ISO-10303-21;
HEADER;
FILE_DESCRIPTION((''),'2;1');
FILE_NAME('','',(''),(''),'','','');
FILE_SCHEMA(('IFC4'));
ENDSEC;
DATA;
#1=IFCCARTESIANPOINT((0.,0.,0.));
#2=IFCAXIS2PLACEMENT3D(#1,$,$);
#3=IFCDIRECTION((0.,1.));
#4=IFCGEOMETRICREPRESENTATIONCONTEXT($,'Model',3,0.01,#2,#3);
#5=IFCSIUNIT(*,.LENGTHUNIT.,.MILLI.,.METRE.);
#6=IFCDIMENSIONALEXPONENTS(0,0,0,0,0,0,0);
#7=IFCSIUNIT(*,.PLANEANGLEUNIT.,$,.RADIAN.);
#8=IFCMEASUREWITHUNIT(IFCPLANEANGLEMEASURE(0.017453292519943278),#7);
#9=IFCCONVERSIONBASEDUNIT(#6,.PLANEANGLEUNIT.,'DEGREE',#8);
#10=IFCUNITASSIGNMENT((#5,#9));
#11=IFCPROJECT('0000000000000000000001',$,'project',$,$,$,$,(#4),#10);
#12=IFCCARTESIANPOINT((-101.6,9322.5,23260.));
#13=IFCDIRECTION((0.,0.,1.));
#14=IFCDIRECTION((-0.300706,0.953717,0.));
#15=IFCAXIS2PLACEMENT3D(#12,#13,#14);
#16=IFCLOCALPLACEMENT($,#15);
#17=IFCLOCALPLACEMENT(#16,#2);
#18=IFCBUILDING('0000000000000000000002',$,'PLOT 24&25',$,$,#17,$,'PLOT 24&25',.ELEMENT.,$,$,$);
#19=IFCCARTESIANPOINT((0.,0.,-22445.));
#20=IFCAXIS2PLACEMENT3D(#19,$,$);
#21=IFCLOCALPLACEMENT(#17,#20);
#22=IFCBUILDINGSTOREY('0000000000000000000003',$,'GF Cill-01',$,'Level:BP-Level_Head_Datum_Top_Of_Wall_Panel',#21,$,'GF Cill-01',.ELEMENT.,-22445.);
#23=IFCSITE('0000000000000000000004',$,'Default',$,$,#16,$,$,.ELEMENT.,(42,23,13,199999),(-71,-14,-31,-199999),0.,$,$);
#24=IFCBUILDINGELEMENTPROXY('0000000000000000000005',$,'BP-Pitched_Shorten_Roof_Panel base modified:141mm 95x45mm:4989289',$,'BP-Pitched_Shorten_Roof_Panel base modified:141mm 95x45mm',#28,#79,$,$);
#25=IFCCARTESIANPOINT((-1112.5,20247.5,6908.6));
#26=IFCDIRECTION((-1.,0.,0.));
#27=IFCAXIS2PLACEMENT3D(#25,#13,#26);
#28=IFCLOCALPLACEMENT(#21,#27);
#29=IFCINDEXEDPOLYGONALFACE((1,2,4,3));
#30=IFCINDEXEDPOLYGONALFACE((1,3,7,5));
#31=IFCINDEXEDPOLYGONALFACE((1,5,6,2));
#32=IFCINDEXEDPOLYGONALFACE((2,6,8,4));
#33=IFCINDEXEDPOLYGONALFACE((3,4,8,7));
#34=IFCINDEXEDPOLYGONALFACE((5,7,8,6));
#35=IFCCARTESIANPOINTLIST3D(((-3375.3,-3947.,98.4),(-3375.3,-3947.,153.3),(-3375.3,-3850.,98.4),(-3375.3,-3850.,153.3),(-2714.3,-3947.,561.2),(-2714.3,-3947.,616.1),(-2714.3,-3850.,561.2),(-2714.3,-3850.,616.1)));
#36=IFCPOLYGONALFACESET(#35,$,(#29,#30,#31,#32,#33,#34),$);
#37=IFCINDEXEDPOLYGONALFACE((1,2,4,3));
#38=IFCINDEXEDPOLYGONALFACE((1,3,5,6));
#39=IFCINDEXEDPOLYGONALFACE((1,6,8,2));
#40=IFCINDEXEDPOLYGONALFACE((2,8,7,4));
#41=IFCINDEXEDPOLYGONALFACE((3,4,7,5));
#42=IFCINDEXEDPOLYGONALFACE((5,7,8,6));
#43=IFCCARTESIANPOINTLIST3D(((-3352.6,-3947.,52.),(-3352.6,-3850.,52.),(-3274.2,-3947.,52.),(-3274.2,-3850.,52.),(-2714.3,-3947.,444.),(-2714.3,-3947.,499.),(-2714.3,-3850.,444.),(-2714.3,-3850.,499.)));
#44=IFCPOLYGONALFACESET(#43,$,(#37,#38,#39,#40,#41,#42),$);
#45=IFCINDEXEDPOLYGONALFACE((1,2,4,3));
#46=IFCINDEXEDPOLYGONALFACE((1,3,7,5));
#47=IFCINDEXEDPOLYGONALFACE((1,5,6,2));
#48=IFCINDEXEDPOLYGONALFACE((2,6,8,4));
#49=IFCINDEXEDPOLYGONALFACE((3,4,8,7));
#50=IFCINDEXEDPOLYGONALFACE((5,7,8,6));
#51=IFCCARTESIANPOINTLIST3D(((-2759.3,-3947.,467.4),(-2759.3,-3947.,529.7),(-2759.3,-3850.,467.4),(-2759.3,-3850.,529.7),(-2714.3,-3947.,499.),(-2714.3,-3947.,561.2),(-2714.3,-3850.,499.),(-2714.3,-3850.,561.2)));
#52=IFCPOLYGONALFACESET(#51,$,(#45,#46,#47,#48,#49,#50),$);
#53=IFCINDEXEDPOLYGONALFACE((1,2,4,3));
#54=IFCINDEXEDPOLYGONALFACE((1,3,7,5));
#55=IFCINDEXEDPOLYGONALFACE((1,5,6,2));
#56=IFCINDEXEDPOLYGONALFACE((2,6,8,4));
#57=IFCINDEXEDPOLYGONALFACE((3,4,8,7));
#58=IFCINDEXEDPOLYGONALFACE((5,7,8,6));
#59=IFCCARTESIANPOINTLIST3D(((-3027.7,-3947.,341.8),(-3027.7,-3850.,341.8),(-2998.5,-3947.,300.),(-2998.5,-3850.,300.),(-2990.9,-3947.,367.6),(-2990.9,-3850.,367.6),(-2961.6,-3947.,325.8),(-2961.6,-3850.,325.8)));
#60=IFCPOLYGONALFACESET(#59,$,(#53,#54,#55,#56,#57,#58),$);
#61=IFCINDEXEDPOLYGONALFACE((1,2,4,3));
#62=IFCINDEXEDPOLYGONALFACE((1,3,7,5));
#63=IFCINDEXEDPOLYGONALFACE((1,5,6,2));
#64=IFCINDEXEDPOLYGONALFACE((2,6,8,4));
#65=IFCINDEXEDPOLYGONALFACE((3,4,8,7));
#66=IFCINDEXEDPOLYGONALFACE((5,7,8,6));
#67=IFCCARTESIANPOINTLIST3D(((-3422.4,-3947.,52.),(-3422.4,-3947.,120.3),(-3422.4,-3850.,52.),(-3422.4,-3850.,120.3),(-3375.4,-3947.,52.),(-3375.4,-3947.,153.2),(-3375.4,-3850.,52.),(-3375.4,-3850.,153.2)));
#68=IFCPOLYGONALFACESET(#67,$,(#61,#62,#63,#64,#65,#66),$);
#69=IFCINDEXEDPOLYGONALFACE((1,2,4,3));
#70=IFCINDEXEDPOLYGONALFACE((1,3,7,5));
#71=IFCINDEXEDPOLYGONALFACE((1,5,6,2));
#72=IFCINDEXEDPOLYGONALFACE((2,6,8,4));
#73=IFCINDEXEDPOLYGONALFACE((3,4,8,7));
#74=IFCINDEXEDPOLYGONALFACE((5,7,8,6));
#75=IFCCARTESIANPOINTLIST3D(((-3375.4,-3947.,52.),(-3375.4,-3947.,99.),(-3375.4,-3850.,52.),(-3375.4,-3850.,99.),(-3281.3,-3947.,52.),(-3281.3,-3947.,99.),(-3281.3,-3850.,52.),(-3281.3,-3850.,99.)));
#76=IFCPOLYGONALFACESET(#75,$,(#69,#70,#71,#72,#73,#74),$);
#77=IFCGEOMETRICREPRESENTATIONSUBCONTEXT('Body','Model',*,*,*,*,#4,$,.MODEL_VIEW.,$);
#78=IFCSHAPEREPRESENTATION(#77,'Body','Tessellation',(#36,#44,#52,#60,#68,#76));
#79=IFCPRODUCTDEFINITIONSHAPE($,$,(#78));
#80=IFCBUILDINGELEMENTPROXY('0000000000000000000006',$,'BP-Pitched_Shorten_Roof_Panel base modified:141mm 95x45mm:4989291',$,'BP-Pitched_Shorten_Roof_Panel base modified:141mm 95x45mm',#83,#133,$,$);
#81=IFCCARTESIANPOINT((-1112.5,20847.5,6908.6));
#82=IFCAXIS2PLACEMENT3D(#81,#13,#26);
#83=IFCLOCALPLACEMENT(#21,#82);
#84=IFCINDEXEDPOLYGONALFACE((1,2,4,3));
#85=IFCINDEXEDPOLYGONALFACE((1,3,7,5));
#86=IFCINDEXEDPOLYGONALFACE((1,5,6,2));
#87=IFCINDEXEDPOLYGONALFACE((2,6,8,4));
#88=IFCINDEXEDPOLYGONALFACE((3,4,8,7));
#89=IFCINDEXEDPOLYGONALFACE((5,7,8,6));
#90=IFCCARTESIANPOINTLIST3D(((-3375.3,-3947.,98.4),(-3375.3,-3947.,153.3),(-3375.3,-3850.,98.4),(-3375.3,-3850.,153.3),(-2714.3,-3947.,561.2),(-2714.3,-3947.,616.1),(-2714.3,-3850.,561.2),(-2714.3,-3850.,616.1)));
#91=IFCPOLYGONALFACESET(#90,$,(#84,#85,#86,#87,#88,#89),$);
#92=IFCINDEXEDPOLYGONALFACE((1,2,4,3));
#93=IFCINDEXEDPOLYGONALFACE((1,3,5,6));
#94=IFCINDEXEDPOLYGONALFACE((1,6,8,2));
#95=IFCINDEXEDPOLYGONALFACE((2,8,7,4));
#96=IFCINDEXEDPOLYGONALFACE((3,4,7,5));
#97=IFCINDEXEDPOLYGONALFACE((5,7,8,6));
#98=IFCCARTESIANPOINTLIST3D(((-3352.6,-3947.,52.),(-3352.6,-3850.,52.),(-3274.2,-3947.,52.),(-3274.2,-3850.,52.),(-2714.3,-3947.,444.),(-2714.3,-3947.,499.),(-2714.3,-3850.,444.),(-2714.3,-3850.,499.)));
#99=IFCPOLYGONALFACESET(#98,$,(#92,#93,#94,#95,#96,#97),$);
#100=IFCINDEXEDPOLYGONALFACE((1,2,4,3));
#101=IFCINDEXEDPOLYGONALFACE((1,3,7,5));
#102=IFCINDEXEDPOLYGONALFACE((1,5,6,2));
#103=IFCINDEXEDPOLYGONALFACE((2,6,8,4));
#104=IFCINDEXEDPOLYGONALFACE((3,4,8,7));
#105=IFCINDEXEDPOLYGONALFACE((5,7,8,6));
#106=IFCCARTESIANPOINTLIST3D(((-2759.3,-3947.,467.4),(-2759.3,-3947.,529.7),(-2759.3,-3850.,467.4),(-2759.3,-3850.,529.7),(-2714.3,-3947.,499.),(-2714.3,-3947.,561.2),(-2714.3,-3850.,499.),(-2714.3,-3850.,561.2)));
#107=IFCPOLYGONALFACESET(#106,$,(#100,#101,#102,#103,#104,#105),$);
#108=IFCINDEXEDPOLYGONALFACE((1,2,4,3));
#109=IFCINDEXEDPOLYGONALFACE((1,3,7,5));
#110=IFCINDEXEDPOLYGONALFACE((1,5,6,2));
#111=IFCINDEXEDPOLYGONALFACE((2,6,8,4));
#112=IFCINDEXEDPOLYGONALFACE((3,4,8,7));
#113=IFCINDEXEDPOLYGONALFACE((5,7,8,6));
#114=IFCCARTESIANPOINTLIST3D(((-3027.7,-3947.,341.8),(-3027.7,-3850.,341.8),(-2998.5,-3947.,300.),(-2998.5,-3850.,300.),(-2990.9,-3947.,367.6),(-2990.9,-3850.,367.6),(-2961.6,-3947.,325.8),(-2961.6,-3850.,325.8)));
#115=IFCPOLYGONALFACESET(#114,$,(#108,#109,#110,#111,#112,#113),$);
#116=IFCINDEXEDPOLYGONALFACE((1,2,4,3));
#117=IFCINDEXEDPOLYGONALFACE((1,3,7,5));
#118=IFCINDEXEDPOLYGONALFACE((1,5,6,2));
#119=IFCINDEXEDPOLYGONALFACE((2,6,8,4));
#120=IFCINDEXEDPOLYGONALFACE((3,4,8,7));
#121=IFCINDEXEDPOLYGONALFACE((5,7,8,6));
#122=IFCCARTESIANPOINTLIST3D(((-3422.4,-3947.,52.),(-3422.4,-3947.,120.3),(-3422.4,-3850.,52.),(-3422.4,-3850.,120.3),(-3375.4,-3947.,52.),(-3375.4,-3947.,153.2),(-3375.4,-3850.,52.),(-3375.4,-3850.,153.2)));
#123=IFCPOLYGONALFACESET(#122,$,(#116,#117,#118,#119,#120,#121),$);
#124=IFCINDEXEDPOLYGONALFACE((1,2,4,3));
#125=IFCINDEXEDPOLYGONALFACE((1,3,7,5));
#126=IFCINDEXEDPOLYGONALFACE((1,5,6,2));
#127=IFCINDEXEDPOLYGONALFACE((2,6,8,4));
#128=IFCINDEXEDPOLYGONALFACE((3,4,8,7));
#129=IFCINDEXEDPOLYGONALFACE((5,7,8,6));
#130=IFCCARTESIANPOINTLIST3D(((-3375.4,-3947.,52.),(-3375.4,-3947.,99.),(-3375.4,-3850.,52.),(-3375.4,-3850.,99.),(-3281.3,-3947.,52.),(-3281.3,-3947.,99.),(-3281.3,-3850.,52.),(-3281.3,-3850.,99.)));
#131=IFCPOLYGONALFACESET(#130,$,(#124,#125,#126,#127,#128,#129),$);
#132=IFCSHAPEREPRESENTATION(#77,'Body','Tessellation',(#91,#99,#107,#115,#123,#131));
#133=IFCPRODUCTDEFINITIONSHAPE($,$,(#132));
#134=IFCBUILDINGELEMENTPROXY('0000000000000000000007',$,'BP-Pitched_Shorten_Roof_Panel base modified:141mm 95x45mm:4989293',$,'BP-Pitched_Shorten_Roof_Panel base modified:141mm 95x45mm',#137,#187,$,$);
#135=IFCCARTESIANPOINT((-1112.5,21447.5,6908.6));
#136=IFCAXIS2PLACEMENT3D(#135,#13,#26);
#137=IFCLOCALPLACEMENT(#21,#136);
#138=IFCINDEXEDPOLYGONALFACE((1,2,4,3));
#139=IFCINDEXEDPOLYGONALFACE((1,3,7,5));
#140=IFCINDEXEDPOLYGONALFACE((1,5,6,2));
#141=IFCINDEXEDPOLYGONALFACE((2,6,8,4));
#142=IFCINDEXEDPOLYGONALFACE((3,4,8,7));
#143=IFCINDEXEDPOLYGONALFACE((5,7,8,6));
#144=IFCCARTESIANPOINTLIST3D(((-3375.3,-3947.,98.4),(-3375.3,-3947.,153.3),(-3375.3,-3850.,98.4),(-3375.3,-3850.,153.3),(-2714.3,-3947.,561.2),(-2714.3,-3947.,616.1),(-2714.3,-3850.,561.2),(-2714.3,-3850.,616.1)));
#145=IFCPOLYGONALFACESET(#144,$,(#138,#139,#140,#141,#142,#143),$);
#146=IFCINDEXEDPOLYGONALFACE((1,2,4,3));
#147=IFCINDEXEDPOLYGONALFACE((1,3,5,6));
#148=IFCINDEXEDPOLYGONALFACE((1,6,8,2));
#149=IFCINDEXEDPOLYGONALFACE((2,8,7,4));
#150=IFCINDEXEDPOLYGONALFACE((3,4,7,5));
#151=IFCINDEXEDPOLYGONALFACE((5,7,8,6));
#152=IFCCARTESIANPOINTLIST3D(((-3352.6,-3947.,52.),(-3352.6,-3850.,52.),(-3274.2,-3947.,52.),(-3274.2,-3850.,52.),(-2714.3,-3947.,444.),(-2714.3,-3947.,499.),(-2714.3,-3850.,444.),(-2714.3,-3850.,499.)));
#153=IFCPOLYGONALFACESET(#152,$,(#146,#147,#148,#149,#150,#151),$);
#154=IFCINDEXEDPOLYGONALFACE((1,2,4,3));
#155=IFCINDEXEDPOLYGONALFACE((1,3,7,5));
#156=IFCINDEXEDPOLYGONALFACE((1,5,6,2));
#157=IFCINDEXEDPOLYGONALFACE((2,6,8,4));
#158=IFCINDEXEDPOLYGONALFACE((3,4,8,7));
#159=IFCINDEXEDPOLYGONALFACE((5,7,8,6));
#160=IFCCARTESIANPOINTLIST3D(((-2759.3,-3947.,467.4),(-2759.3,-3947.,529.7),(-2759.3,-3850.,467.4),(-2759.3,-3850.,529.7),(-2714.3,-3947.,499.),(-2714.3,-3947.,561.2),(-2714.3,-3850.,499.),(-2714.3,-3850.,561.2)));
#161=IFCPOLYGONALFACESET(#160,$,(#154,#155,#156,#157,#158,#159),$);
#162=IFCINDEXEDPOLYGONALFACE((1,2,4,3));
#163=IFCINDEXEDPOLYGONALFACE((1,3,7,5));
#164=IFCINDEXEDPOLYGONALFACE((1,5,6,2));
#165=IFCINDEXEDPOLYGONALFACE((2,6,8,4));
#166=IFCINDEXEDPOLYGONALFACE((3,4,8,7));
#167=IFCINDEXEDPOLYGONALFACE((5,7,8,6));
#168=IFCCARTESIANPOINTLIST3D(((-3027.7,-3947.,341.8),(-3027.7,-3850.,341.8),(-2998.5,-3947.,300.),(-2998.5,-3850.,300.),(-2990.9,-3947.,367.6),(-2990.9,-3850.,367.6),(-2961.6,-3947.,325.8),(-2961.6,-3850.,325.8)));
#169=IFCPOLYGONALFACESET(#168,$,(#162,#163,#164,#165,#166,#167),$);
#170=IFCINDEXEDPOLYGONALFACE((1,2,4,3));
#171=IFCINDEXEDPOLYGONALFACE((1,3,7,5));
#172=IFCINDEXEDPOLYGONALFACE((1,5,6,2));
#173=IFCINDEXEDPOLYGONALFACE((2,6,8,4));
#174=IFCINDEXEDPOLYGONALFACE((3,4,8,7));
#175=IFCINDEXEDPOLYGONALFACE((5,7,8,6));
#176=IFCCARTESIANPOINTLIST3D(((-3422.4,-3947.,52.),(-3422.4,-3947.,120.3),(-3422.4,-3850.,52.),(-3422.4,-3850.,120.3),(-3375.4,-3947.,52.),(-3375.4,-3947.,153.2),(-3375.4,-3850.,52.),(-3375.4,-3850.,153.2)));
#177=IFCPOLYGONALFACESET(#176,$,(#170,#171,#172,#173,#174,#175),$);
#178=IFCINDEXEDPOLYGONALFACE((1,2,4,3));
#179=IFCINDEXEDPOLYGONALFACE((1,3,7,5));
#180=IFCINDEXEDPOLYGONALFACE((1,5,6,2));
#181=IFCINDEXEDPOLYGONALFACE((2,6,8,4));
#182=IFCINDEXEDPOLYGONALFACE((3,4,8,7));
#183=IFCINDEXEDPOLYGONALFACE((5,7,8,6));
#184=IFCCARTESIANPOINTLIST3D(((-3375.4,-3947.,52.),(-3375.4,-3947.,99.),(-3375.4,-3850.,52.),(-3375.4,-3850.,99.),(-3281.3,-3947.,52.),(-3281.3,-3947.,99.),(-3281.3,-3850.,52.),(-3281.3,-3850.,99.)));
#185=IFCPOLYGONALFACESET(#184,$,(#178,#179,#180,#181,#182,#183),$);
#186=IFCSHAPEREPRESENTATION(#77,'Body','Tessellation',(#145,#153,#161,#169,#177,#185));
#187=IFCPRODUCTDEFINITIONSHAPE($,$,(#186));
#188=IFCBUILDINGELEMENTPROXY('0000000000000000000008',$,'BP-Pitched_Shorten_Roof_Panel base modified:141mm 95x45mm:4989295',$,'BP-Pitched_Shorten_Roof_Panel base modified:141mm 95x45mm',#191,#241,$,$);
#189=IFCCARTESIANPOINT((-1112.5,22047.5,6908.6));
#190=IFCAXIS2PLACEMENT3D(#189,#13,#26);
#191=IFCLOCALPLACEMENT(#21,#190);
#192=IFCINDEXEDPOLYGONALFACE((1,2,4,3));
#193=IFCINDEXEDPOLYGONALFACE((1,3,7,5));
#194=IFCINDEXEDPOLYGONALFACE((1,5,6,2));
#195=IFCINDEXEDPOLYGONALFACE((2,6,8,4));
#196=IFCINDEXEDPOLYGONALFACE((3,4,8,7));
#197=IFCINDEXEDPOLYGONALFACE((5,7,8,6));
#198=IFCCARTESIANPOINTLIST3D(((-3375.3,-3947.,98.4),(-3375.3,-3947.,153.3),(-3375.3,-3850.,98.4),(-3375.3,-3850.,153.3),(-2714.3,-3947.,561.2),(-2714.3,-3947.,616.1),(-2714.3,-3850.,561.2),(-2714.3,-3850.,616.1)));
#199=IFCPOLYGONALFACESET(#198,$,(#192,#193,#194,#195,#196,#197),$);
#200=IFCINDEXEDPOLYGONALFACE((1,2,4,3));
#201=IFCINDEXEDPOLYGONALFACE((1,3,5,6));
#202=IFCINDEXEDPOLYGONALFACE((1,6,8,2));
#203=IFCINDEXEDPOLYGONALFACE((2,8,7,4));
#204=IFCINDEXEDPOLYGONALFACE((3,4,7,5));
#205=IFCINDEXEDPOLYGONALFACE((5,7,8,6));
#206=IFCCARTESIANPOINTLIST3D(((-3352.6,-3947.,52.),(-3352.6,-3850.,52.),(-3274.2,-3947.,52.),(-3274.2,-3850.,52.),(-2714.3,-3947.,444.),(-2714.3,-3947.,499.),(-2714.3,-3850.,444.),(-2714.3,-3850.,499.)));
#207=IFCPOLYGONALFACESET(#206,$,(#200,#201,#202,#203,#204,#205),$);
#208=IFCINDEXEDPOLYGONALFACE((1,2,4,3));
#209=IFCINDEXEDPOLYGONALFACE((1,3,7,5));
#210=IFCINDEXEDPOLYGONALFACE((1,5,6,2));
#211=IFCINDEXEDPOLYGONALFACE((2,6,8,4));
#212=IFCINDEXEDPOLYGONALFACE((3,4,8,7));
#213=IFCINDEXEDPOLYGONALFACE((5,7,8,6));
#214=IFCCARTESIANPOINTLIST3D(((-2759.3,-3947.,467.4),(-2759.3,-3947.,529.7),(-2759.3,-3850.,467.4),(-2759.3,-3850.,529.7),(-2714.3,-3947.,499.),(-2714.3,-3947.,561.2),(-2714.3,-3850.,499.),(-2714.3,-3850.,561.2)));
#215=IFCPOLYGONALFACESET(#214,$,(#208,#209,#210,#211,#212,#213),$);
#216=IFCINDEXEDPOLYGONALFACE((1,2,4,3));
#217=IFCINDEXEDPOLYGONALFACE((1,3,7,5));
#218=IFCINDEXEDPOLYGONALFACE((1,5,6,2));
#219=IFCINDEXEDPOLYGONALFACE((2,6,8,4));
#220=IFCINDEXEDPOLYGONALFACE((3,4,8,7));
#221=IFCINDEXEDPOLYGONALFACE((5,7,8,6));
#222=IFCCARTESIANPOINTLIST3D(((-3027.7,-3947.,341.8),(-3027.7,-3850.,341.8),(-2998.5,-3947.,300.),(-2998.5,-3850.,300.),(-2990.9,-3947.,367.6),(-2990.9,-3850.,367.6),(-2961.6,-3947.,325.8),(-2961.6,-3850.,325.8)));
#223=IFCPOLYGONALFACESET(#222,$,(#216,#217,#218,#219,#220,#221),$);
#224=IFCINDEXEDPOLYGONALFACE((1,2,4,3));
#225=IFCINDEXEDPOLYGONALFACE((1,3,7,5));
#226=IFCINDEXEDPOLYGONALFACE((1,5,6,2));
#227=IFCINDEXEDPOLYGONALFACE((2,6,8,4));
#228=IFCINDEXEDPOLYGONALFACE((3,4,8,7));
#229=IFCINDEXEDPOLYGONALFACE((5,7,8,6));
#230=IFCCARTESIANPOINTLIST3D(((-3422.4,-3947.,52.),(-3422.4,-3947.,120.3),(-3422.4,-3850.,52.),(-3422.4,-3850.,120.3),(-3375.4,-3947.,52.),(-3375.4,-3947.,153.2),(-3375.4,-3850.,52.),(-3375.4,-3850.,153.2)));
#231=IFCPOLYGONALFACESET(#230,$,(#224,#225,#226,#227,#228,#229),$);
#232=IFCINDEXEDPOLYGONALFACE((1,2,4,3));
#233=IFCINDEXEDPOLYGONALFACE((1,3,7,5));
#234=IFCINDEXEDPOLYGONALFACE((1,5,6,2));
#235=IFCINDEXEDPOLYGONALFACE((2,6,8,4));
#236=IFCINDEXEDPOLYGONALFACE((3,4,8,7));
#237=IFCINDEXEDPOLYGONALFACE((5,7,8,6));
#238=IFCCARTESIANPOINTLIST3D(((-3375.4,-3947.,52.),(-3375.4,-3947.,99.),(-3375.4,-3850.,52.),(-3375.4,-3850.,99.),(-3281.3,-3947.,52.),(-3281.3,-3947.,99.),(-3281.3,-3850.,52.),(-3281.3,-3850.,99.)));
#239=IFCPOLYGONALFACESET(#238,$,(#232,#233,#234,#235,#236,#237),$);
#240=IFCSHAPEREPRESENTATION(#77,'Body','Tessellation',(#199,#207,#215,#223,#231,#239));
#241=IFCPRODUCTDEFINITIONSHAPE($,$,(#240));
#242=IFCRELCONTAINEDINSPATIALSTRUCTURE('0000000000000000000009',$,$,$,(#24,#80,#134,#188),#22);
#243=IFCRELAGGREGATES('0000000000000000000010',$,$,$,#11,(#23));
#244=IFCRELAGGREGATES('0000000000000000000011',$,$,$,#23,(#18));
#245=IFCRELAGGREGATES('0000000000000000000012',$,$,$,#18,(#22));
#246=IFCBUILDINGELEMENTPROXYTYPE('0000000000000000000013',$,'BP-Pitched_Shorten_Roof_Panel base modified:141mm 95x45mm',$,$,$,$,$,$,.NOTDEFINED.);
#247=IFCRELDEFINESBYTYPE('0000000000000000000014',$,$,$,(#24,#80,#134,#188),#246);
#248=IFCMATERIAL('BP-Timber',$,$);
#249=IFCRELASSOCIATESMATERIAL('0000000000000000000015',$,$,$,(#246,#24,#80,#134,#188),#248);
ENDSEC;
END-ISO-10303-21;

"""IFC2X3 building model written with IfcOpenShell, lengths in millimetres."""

from ifc_helpers import new_model, entity, si_unit, converted_unit, direction, frame, frame_2d, origin, origin_2d_with_axis, place, context, subcontext, project, spatial, polyline, rectangle, outline, extrude, source, transform, mapped, material, type_object, type_shapes, element, save


model = new_model("IFC2X3")

# Units and contexts
model_context = context("Model", 3, precision=0.01, world=origin(), true_north=direction((0.0, 1.0)))
body_context = subcontext(model_context, "Body", "Model", "MODEL_VIEW")
ifc_project = project(units=[si_unit("LENGTHUNIT", "METRE", prefix="MILLI"), converted_unit("PLANEANGLEUNIT", "DEGREE", entity("IfcPlaneAngleMeasure", 0.017453292519943278), si_unit("PLANEANGLEUNIT", "RADIAN"), dimensions=[0, 0, 0, 0, 0, 0, 0])], contexts=[model_context])

# Site, building, storey
site_placement = place(None, frame((-101.6, 9322.5, 23260.0), z_axis=(0.0, 0.0, 1.0), x_axis=(-0.300706, 0.953717, 0.0)))
site = spatial("IfcSite", under=ifc_project, at=site_placement, Name="Default", CompositionType="ELEMENT", RefLatitude=(42, 23, 13, 199999), RefLongitude=(-71, -14, -31, -199999), RefElevation=0.0)
building_placement = place(site_placement, origin())
building = spatial("IfcBuilding", under=site, at=building_placement, Name="PLOT 24&25", LongName="PLOT 24&25", CompositionType="ELEMENT")
storey_placement = place(building_placement, frame((0.0, 0.0, -22445.0)))
storey = spatial("IfcBuildingStorey", under=building, at=storey_placement, Name="GF Cill-01", ObjectType="Level:BP-Level_Head_Datum_Top_Of_Wall_Panel", LongName="GF Cill-01", CompositionType="ELEMENT", Elevation=-22445.0)

# Shared definitions
ifc_material_1 = material(Name="BP-Timber")

# Building element proxies
building_element_proxy_type_1 = type_object("IfcBuildingElementProxyType", Name="BP-Pitched_Shorten_Roof_Panel base modified:141mm 95x45mm", PredefinedType="NOTDEFINED", material=ifc_material_1)
shared_shape_1 = source(origin(), body_context, "Body", "SweptSolid", [
    extrude(outline(polyline([(-258.9, -330.5), (-204.0, -330.5), (258.9, 330.5), (204.0, 330.5), (-258.9, -330.5)])), frame((-3044.8, -3947.0, 357.3), z_axis=(0.0, 1.0, 0.0), x_axis=(0.0, 0.0, -1.0)), (0.0, 0.0, 1.0), 97.0),
    extrude(outline(polyline([(-237.2, -299.5), (-182.3, -299.5), (209.7, 260.3), (209.7, 338.8), (-237.2, -299.5)])), frame((-3013.9, -3947.0, 261.7), z_axis=(0.0, 1.0, 0.0), x_axis=(0.0, 0.0, -1.0)), (0.0, 0.0, 1.0), 97.0),
    extrude(outline(polyline([(-9.6, -25.5), (45.3, -25.5), (9.6, 25.5), (-45.3, 25.5), (-9.6, -25.5)])), frame((-2736.8, -3947.0, 514.3), z_axis=(0.0, 1.0, 0.0), x_axis=(0.819152, 0.0, 0.573576)), (0.0, 0.0, 1.0), 97.0),
    extrude(rectangle(XDim=51.0, YDim=45.0, at=origin_2d_with_axis()), frame((-2994.7, -3947.0, 333.8), z_axis=(0.0, 1.0, 0.0), x_axis=(0.573576, 0.0, -0.819152)), (0.0, 0.0, 1.0), 97.0),
    extrude(outline(polyline([(-58.9, -23.5), (42.4, -23.5), (42.4, 23.5), (-25.9, 23.5), (-58.9, -23.5)])), frame((-3398.9, -3947.0, 94.4), z_axis=(0.0, 1.0, 0.0), x_axis=(0.0, 0.0, -1.0)), (0.0, 0.0, 1.0), 97.0),
    extrude(rectangle(XDim=94.1, YDim=97.0, at=frame_2d((0.0, 0.0), x_axis=(1.0, 0.0))), frame((-3328.4, -3898.5, 52.0), z_axis=(0.0, 0.0, 1.0), x_axis=(-1.0, 0.0, 0.0)), (0.0, 0.0, 1.0), 47.0),
])
type_shapes(building_element_proxy_type_1, [shared_shape_1])
for number, where, z_axis, x_axis, name in (
    (1, (-1112.5, 20247.5, 6908.6), (0.0, 0.0, 1.0), (-1.0, 0.0, 0.0), "BP-Pitched_Shorten_Roof_Panel base modified:141mm 95x45mm:4989289"),
    (2, (-1112.5, 20847.5, 6908.6), (0.0, 0.0, 1.0), (-1.0, 0.0, 0.0), "BP-Pitched_Shorten_Roof_Panel base modified:141mm 95x45mm:4989291"),
    (3, (-1112.5, 21447.5, 6908.6), (0.0, 0.0, 1.0), (-1.0, 0.0, 0.0), "BP-Pitched_Shorten_Roof_Panel base modified:141mm 95x45mm:4989293"),
    (4, (-1112.5, 22047.5, 6908.6), (0.0, 0.0, 1.0), (-1.0, 0.0, 0.0), "BP-Pitched_Shorten_Roof_Panel base modified:141mm 95x45mm:4989295"),
):
    element("IfcBuildingElementProxy", number, at=place(storey_placement, frame(where, z_axis=z_axis, x_axis=x_axis)), inside=storey, type_object=building_element_proxy_type_1, material=ifc_material_1, Name=name, ObjectType="BP-Pitched_Shorten_Roof_Panel base modified:141mm 95x45mm", context=body_context, shape_type="MappedRepresentation", body=[
        mapped(shared_shape_1, transform((0.0, 0.0, 0.0), scale=1.0)),
    ])

save(model, "model.ifc")
